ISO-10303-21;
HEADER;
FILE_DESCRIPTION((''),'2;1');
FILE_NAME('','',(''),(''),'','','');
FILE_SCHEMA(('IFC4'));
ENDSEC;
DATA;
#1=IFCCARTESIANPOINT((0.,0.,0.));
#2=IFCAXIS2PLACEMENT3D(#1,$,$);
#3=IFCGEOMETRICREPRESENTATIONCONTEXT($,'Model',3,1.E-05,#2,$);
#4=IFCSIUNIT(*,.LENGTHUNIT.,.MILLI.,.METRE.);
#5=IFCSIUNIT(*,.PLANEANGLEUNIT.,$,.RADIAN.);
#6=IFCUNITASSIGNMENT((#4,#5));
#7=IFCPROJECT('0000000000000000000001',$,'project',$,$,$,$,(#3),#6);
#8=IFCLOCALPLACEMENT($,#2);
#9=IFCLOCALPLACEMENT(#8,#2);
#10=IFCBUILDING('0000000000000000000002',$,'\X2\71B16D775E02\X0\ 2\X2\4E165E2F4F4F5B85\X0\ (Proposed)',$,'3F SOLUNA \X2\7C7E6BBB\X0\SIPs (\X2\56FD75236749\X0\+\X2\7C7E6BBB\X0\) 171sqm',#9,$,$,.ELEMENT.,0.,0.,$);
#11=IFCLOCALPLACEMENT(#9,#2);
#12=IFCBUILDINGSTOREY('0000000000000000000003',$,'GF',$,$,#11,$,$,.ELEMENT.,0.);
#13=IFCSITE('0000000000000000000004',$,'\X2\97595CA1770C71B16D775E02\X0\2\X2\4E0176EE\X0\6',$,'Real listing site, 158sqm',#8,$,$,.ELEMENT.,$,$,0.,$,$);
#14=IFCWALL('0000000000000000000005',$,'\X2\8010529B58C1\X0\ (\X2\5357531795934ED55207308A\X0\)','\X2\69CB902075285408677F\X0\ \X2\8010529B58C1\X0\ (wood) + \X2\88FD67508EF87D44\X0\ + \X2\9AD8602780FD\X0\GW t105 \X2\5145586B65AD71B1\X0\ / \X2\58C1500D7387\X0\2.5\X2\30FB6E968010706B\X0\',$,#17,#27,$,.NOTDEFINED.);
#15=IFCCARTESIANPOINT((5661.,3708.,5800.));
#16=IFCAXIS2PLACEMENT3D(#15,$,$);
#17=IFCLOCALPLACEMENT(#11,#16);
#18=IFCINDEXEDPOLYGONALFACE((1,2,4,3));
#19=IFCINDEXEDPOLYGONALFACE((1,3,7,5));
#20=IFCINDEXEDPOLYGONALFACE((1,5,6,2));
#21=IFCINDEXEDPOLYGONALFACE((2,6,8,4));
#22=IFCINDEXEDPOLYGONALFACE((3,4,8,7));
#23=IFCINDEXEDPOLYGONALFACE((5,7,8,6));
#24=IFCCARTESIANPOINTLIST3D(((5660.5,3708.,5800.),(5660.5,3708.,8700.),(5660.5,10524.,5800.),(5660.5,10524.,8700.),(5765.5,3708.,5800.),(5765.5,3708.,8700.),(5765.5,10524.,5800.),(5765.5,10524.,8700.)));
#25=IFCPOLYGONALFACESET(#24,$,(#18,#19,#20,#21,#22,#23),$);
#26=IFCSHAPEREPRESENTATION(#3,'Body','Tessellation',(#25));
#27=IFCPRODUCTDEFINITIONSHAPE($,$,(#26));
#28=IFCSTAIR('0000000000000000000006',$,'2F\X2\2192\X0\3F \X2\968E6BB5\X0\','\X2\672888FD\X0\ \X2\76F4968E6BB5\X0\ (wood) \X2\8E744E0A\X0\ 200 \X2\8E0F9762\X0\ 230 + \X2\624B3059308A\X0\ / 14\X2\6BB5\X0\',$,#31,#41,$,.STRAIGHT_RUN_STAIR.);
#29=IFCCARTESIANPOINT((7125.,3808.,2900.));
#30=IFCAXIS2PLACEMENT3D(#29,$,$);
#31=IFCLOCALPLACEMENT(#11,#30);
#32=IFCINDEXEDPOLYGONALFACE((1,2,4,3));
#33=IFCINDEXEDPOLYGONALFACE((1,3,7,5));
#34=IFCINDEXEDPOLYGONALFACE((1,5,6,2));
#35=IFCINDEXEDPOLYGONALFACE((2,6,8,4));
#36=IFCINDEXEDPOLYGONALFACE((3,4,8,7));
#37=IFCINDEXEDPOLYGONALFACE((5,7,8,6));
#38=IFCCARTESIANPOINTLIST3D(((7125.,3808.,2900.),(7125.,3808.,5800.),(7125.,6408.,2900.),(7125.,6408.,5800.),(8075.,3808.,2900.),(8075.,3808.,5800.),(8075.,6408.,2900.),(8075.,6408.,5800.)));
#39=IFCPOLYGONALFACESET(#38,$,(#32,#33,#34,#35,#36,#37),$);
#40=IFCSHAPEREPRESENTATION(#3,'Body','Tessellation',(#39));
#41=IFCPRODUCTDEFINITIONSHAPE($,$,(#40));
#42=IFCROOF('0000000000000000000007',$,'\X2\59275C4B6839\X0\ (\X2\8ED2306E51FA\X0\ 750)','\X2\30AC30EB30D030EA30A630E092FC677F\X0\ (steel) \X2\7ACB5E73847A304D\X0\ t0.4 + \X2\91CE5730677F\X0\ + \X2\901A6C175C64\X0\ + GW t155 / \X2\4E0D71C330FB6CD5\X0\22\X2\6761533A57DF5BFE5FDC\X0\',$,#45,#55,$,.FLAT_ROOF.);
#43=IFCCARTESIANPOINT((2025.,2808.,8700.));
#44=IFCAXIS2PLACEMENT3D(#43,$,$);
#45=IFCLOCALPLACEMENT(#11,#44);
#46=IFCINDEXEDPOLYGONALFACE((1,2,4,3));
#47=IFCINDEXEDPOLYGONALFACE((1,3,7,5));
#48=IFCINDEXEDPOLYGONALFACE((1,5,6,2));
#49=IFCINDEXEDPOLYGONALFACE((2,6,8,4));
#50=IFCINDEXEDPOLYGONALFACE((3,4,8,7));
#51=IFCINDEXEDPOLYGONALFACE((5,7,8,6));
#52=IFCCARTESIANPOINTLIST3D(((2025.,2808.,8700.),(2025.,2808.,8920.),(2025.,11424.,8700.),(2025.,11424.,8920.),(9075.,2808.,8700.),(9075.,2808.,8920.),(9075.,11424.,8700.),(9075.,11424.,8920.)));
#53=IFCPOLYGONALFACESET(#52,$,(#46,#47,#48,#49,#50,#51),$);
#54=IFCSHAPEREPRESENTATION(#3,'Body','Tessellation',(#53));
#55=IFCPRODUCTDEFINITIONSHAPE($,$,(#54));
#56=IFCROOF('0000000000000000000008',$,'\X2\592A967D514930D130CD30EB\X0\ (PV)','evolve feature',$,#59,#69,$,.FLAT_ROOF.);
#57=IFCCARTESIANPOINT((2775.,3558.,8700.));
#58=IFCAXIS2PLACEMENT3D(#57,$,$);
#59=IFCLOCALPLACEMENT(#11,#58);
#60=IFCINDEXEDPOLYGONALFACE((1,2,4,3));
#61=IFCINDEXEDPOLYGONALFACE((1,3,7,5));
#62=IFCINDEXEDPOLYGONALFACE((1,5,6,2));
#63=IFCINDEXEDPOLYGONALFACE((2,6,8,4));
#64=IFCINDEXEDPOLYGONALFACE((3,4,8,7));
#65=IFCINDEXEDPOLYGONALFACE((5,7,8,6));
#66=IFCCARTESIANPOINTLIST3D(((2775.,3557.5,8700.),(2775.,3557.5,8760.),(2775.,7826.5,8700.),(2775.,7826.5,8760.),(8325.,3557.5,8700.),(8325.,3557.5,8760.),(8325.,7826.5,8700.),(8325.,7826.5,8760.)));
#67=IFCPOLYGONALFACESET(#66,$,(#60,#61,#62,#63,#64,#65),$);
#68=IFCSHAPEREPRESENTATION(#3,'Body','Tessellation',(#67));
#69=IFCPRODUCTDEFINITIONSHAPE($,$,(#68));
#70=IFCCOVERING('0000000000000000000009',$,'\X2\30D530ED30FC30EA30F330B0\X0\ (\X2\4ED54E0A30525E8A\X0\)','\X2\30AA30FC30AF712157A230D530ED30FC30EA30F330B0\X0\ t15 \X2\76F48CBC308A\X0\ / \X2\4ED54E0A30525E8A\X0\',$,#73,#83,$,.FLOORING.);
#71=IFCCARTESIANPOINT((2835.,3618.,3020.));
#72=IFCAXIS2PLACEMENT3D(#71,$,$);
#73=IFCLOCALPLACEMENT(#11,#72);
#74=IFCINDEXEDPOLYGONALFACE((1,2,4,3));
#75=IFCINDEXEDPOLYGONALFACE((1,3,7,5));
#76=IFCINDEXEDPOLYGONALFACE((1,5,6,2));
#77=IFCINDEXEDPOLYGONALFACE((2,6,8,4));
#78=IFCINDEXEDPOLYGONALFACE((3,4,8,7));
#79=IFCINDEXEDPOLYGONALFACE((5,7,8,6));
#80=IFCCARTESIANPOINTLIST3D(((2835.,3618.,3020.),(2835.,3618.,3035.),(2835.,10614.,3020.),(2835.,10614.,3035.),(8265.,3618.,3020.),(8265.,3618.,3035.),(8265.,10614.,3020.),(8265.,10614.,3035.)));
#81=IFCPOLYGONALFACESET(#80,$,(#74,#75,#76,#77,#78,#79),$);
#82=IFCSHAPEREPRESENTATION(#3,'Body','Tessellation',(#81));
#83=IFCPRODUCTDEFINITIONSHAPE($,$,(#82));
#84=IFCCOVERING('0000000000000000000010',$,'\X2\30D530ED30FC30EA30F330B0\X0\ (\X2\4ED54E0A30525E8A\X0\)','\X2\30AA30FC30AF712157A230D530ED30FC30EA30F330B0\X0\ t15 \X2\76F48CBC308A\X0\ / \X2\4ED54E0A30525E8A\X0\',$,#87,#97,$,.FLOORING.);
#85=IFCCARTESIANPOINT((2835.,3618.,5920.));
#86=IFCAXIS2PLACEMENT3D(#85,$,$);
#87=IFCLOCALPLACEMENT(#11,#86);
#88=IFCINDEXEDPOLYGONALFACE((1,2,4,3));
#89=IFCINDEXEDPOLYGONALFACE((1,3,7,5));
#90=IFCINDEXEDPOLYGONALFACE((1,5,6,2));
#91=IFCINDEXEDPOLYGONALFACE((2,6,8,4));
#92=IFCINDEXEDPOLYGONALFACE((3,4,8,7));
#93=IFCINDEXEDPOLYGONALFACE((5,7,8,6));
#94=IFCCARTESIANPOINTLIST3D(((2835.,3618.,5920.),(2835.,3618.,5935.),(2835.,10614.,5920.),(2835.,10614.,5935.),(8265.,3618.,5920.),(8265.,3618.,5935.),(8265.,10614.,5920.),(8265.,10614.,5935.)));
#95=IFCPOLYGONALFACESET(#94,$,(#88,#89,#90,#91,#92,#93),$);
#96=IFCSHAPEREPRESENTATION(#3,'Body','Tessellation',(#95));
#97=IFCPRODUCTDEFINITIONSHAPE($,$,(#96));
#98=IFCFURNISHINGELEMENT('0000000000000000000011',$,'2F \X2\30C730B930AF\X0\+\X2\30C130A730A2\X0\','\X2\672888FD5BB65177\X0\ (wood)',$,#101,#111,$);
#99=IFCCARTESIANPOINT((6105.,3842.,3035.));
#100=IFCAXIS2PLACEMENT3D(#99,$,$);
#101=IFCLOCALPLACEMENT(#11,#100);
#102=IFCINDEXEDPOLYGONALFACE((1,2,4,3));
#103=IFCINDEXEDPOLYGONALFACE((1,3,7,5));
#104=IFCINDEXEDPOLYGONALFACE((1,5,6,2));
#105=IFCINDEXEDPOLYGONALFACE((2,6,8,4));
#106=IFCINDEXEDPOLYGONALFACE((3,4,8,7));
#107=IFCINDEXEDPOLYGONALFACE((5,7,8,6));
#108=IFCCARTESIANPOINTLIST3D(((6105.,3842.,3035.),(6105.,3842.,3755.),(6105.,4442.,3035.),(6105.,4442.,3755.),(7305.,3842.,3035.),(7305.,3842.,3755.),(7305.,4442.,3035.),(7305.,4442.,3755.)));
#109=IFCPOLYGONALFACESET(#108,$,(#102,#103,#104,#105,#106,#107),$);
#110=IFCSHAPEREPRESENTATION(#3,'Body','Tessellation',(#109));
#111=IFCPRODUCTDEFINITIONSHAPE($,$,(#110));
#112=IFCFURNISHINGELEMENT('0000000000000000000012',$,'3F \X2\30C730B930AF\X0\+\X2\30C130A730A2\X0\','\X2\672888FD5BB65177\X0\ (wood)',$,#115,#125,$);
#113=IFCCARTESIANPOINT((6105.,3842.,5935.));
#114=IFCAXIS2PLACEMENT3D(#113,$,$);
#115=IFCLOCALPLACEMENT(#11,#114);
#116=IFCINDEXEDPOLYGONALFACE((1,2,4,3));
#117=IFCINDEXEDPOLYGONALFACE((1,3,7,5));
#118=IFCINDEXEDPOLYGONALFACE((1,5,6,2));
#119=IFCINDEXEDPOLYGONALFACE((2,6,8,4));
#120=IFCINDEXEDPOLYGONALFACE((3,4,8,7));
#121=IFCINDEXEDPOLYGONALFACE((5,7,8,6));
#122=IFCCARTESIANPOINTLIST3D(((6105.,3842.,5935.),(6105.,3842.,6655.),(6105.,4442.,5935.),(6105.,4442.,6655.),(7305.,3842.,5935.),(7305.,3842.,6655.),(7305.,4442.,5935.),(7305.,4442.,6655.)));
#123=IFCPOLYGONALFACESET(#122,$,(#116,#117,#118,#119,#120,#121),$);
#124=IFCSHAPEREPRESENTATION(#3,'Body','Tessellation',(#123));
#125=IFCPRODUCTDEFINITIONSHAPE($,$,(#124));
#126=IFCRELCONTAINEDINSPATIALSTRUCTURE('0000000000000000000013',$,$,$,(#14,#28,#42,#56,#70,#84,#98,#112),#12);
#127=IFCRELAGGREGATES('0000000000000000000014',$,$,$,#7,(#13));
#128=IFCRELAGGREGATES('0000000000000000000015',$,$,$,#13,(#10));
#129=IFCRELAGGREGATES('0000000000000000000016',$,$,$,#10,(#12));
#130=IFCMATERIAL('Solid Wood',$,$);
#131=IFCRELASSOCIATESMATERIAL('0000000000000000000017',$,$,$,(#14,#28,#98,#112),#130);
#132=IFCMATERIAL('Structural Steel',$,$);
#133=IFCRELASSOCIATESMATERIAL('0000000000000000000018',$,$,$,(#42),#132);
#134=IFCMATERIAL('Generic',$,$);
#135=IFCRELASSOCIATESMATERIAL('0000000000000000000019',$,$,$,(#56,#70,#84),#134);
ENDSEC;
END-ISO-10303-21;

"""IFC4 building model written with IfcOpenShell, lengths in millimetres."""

from ifc_helpers import new_model, si_unit, frame, frame_2d, origin, place, context, project, spatial, rectangle, extrude, material, element, save


model = new_model("IFC4")

# Units and contexts
model_context = context("Model", 3, precision=1e-05, world=origin())
ifc_project = project(units=[si_unit("LENGTHUNIT", "METRE", prefix="MILLI"), si_unit("PLANEANGLEUNIT", "RADIAN")], contexts=[model_context])

# Site, building, storey
site_placement = place(None, origin())
site = spatial("IfcSite", under=ifc_project, at=site_placement, Name="静岡県熱海市2丁目6", ObjectType="Real listing site, 158sqm", CompositionType="ELEMENT", RefElevation=0.0)
building_placement = place(site_placement, origin())
building = spatial("IfcBuilding", under=site, at=building_placement, Name="熱海市 2世帯住宅 (Proposed)", ObjectType="3F SOLUNA 籾殻SIPs (国産杉+籾殻) 171sqm", CompositionType="ELEMENT", ElevationOfRefHeight=0.0, ElevationOfTerrain=0.0)
storey_placement = place(building_placement, origin())
storey = spatial("IfcBuildingStorey", under=building, at=storey_placement, Name="GF", CompositionType="ELEMENT", Elevation=0.0)

# Shared definitions
ifc_material_1 = material(Name="Solid Wood")

# Shared definitions
ifc_material_2 = material(Name="Generic")

# Wall
wall_1_placement = place(storey_placement, frame((5661.0, 3708.0, 5800.0)))
element("IfcWall", 1, at=wall_1_placement, inside=storey, material=ifc_material_1, Name="耐力壁 (南北間仕切り)", Description="構造用合板 耐力壁 (wood) + 製材軸組 + 高性能GW t105 充填断熱 / 壁倍率2.5・準耐火", PredefinedType="NOTDEFINED", context=model_context, shape_type="SweptSolid", body=[
    extrude(rectangle(XDim=105.0, YDim=6816.0, at=frame_2d((52.0, 3408.0))), frame((5661.0, 3708.0, 5800.0)), (0.0, 0.0, 1.0), 2900.0),
])

# Stair
stair_placement = place(storey_placement, frame((7125.0, 3808.0, 2900.0)))
element("IfcStair", 2, at=stair_placement, inside=storey, material=ifc_material_1, Name="2F→3F 階段", Description="木製 直階段 (wood) 蹴上 200 踏面 230 + 手すり / 14段", PredefinedType="STRAIGHT_RUN_STAIR", context=model_context, shape_type="SweptSolid", body=[
    extrude(rectangle(XDim=950.0, YDim=2600.0, at=frame_2d((475.0, 1300.0))), frame((7125.0, 3808.0, 2900.0)), (0.0, 0.0, 1.0), 2900.0),
])

# Roofs
ifc_material_3 = material(Name="Structural Steel")
roof_1_placement = place(storey_placement, frame((2025.0, 2808.0, 8700.0)))
element("IfcRoof", 3, at=roof_1_placement, inside=storey, material=ifc_material_3, Name="大屋根 (軒の出 750)", Description="ガルバリウム鋼板 (steel) 立平葺き t0.4 + 野地板 + 通気層 + GW t155 / 不燃・法22条区域対応", PredefinedType="FLAT_ROOF", context=model_context, shape_type="SweptSolid", body=[
    extrude(rectangle(XDim=7050.0, YDim=8616.0, at=frame_2d((3525.0, 4308.0))), frame((2025.0, 2808.0, 8700.0)), (0.0, 0.0, 1.0), 220.0),
])
roof_2_placement = place(storey_placement, frame((2775.0, 3558.0, 8700.0)))
element("IfcRoof", 4, at=roof_2_placement, inside=storey, material=ifc_material_2, Name="太陽光パネル (PV)", Description="evolve feature", PredefinedType="FLAT_ROOF", context=model_context, shape_type="SweptSolid", body=[
    extrude(rectangle(XDim=5550.0, YDim=4269.0, at=frame_2d((2775.0, 2134.0))), frame((2775.0, 3558.0, 8700.0)), (0.0, 0.0, 1.0), 60.0),
])

# Coverings
covering_1_placement = place(storey_placement, frame((2835.0, 3618.0, 3020.0)))
element("IfcCovering", 5, at=covering_1_placement, inside=storey, material=ifc_material_2, Name="フローリング (仕上げ床)", Description="オーク無垢フローリング t15 直貼り / 仕上げ床", PredefinedType="FLOORING", context=model_context, shape_type="SweptSolid", body=[
    extrude(rectangle(XDim=5430.0, YDim=6996.0, at=frame_2d((2715.0, 3498.0))), frame((2835.0, 3618.0, 3020.0)), (0.0, 0.0, 1.0), 15.0),
])
covering_2_placement = place(storey_placement, frame((2835.0, 3618.0, 5920.0)))
element("IfcCovering", 6, at=covering_2_placement, inside=storey, material=ifc_material_2, Name="フローリング (仕上げ床)", Description="オーク無垢フローリング t15 直貼り / 仕上げ床", PredefinedType="FLOORING", context=model_context, shape_type="SweptSolid", body=[
    extrude(rectangle(XDim=5430.0, YDim=6996.0, at=frame_2d((2715.0, 3498.0))), frame((2835.0, 3618.0, 5920.0)), (0.0, 0.0, 1.0), 15.0),
])

# Furnishing elements
furnishing_1_placement = place(storey_placement, frame((6105.0, 3842.0, 3035.0)))
element("IfcFurnishingElement", 7, at=furnishing_1_placement, inside=storey, material=ifc_material_1, Name="2F デスク+チェア", Description="木製家具 (wood)", context=model_context, shape_type="SweptSolid", body=[
    extrude(rectangle(XDim=1200.0, YDim=600.0, at=frame_2d((600.0, 300.0))), frame((6105.0, 3842.0, 3035.0)), (0.0, 0.0, 1.0), 720.0),
])
furnishing_2_placement = place(storey_placement, frame((6105.0, 3842.0, 5935.0)))
element("IfcFurnishingElement", 8, at=furnishing_2_placement, inside=storey, material=ifc_material_1, Name="3F デスク+チェア", Description="木製家具 (wood)", context=model_context, shape_type="SweptSolid", body=[
    extrude(rectangle(XDim=1200.0, YDim=600.0, at=frame_2d((600.0, 300.0))), frame((6105.0, 3842.0, 5935.0)), (0.0, 0.0, 1.0), 720.0),
])

save(model, "model.ifc")
